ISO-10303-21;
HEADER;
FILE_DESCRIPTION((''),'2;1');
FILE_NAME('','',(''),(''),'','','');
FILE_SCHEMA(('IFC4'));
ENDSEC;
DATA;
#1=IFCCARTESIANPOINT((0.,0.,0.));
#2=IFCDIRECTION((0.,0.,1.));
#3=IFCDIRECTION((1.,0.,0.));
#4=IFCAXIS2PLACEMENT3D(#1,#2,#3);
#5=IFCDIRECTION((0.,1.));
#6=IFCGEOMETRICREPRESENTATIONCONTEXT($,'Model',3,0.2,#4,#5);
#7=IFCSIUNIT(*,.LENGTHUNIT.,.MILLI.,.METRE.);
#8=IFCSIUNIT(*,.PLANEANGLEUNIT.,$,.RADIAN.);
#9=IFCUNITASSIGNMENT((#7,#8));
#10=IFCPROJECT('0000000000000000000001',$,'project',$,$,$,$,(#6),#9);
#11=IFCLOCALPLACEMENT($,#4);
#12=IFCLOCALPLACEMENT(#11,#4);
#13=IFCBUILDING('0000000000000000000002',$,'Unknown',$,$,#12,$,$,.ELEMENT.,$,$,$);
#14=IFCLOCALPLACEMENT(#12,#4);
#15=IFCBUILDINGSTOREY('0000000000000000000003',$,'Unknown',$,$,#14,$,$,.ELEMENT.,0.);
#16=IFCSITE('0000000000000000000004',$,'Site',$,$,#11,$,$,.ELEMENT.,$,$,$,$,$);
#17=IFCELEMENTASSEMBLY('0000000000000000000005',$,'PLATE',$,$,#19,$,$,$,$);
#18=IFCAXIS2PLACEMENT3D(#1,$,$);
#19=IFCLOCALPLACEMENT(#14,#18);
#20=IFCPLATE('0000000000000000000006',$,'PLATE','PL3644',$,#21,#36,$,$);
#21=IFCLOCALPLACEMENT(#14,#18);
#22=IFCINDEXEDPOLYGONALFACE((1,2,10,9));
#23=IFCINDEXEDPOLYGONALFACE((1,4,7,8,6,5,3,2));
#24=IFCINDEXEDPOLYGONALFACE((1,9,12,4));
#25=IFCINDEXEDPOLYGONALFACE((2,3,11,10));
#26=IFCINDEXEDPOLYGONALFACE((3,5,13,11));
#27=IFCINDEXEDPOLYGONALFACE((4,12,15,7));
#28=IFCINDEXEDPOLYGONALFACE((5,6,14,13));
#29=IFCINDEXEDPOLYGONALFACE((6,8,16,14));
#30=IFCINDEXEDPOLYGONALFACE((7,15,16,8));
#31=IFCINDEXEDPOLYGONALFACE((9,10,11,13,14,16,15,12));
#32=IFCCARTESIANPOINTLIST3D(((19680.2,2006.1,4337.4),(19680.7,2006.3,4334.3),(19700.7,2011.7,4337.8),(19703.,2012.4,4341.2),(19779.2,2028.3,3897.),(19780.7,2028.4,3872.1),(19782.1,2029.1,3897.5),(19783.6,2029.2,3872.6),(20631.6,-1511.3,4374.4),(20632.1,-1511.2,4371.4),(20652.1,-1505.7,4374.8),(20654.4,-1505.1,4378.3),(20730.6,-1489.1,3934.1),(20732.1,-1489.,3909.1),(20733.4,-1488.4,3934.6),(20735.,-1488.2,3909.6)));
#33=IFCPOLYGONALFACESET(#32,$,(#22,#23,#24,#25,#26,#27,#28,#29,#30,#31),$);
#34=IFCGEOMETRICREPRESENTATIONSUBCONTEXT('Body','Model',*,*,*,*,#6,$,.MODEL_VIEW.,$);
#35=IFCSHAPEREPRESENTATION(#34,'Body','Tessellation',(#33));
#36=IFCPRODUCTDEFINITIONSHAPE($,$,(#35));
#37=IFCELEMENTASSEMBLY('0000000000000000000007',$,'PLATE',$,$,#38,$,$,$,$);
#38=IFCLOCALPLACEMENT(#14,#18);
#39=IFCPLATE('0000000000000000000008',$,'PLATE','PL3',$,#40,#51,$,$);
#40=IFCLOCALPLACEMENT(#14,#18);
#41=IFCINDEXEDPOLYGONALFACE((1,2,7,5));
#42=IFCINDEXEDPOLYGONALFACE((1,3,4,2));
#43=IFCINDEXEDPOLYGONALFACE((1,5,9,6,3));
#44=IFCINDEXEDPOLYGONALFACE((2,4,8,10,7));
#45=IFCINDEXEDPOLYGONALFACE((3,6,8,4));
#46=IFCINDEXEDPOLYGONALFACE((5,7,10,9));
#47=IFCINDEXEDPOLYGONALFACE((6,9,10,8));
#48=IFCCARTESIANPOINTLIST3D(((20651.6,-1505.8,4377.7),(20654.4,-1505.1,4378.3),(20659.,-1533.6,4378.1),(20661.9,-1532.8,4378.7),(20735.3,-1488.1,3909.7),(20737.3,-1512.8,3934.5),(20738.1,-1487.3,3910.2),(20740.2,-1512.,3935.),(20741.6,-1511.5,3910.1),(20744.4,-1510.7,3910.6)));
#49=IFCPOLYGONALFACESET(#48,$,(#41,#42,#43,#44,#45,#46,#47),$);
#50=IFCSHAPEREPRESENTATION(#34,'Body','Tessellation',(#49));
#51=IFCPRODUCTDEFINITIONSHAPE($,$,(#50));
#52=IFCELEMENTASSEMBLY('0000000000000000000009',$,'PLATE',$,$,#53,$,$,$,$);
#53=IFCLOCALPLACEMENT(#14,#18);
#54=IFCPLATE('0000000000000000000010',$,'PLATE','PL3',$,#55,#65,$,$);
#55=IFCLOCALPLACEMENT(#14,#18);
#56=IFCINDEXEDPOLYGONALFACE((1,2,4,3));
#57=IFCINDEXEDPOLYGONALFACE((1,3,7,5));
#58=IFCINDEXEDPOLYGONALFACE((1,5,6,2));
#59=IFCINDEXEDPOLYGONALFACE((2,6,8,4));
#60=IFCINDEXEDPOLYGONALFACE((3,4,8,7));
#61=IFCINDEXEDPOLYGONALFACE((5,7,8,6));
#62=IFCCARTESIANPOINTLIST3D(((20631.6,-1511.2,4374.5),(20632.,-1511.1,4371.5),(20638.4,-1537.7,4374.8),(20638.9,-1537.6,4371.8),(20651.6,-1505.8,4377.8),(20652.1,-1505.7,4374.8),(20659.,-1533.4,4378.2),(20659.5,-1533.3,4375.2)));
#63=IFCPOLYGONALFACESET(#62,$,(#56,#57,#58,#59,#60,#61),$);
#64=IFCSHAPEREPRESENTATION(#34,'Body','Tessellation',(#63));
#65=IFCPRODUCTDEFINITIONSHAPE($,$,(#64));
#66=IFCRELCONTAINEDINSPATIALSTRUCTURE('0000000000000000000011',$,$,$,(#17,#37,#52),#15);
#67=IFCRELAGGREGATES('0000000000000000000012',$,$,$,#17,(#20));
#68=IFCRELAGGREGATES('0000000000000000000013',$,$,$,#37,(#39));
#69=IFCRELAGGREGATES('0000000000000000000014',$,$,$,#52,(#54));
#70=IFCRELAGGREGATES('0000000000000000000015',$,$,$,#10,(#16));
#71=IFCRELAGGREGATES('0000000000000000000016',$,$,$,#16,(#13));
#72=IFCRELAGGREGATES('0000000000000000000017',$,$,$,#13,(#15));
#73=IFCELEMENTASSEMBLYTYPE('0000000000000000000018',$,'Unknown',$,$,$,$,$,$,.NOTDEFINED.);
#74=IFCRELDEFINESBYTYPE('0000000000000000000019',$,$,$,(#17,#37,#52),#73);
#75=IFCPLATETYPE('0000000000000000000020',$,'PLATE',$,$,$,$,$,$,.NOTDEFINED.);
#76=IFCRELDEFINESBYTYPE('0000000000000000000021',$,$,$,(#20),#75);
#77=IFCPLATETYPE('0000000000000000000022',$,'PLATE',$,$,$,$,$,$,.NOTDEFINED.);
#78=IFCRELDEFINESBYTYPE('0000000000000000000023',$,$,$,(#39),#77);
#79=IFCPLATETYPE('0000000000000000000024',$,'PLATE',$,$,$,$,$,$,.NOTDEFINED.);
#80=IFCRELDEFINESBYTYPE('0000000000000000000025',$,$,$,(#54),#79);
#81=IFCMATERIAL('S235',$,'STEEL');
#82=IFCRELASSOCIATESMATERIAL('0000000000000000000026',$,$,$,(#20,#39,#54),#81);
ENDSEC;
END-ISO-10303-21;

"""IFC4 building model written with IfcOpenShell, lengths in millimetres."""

from ifc_helpers import new_model, si_unit, direction, frame, origin_with_axes, place, context, subcontext, project, spatial, line, indexed_curve, outline, extrude, material, material_profile, profile_set, profile_usage, type_object, element, aggregate, save


model = new_model("IFC4")

# Units and contexts
model_context = context("Model", 3, precision=0.2, world=origin_with_axes(), true_north=direction((0.0, 1.0)))
body_context = subcontext(model_context, "Body", "Model", "MODEL_VIEW")
ifc_project = project(units=[si_unit("LENGTHUNIT", "METRE", prefix="MILLI"), si_unit("PLANEANGLEUNIT", "RADIAN")], contexts=[model_context])

# Site, building, storey
site_placement = place(None, origin_with_axes())
site = spatial("IfcSite", under=ifc_project, at=site_placement, Name="Site", CompositionType="ELEMENT")
building_placement = place(site_placement, origin_with_axes())
building = spatial("IfcBuilding", under=site, at=building_placement, Name="Unknown", CompositionType="ELEMENT")
storey_placement = place(building_placement, origin_with_axes())
storey = spatial("IfcBuildingStorey", under=building, at=storey_placement, Name="Unknown", CompositionType="ELEMENT", Elevation=0.0)

# Shared definitions
element_assembly_type = type_object("IfcElementAssemblyType", Name="Unknown", PredefinedType="NOTDEFINED")

# Shared definitions
ifc_material_1 = material(Name="S235", Category="STEEL")

# Element assemblies, plates
assembly_1_placement = place(storey_placement, frame((20155.9, 247.4, 4355.9), z_axis=(-0.261079, 0.965264, -0.010168), x_axis=(0.952375, 0.259284, 0.160478)))
assembly_1 = element("IfcElementAssembly", 1, at=assembly_1_placement, inside=storey, type_object=element_assembly_type, Name="PLATE")
ifc_material_profile_1 = material_profile(ifc_material_1, outline(indexed_curve([(0.0, 0.0), (24.0, 0.0), (32.4, 450.9), (29.8, 475.8), (26.9, 475.8), (29.4, 450.9), (21.0, 3.0), (0.0, 3.1)], segments=[line(1, 2, 3, 4, 5, 6, 7, 8, 1)])), Name="PL3644")
ifc_profile_set_1 = profile_set([ifc_material_profile_1])
ifc_profile_usage_1 = profile_usage(ifc_profile_set_1, cardinal=5)
plate_type_1 = type_object("IfcPlateType", Name="PLATE", PredefinedType="NOTDEFINED")
plate_1_placement = place(assembly_1_placement, origin_with_axes())
plate_1 = element("IfcPlate", 2, at=plate_1_placement, type_object=plate_type_1, material=ifc_profile_usage_1, Name="PLATE", Description="PL3644", context=body_context, shape_type="SolidModel", body=[
    extrude(outline(indexed_curve([(0.0, 0.0), (24.0, 0.0), (32.4, 450.9), (29.8, 475.8), (26.9, 475.8), (29.4, 450.9), (21.0, 3.0), (0.0, 3.1)], segments=[line(1, 2, 3, 4, 5, 6, 7, 8, 1)])), frame((0.0, 0.0, 1822.0), z_axis=(0.0, 0.0, 1.0), x_axis=(1.0, 0.0, 0.0)), (0.0, 0.0, -1.0), 3644.0),
])
aggregate(assembly_1, [plate_1])
assembly_2_placement = place(storey_placement, frame((20653.0, -1505.4, 4378.0), z_axis=(0.94912, 0.258677, 0.179601), x_axis=(0.26051, -0.965374, 0.013724)))
assembly_2 = element("IfcElementAssembly", 3, at=assembly_2_placement, inside=storey, type_object=element_assembly_type, Name="PLATE")
ifc_material_profile_2 = material_profile(ifc_material_1, outline(indexed_curve([(0.0, 0.0), (28.7, 0.0), (23.0, 450.9), (22.5, 475.7), (-1.7, 475.8)], segments=[line(1, 2, 3, 4, 5, 1)])), Name="PL3")
ifc_profile_set_2 = profile_set([ifc_material_profile_2])
ifc_profile_usage_2 = profile_usage(ifc_profile_set_2, cardinal=5)
plate_type_2 = type_object("IfcPlateType", Name="PLATE", PredefinedType="NOTDEFINED")
plate_2_placement = place(assembly_2_placement, origin_with_axes())
plate_2 = element("IfcPlate", 4, at=plate_2_placement, type_object=plate_type_2, material=ifc_profile_usage_2, Name="PLATE", Description="PL3", context=body_context, shape_type="SolidModel", body=[
    extrude(outline(indexed_curve([(0.0, 0.0), (28.7, 0.0), (23.0, 450.9), (22.5, 475.7), (-1.7, 475.8)], segments=[line(1, 2, 3, 4, 5, 1)])), frame((0.0, 0.0, 1.5), z_axis=(0.0, 0.0, 1.0), x_axis=(1.0, 0.0, 0.0)), (0.0, 0.0, -1.0), 3.0),
])
aggregate(assembly_2, [plate_2])
assembly_3_placement = place(storey_placement, frame((20638.6, -1537.6, 4373.3), z_axis=(-0.15599, -0.028213, 0.987356), x_axis=(0.966796, 0.200481, 0.158471)))
assembly_3 = element("IfcElementAssembly", 5, at=assembly_3_placement, inside=storey, type_object=element_assembly_type, Name="PLATE")
ifc_material_profile_3 = material_profile(ifc_material_1, outline(indexed_curve([(0.0, 0.0), (21.3, 0.0), (19.6, 28.6), (-1.3, 27.3)], segments=[line(1, 2, 3, 4, 1)])), Name="PL3")
ifc_profile_set_3 = profile_set([ifc_material_profile_3])
ifc_profile_usage_3 = profile_usage(ifc_profile_set_3, cardinal=5)
plate_type_3 = type_object("IfcPlateType", Name="PLATE", PredefinedType="NOTDEFINED")
plate_3_placement = place(assembly_3_placement, origin_with_axes())
plate_3 = element("IfcPlate", 6, at=plate_3_placement, type_object=plate_type_3, material=ifc_profile_usage_3, Name="PLATE", Description="PL3", context=body_context, shape_type="SolidModel", body=[
    extrude(outline(indexed_curve([(0.0, 0.0), (21.3, 0.0), (19.6, 28.6), (-1.3, 27.3)], segments=[line(1, 2, 3, 4, 1)])), frame((0.0, 0.0, 1.5), z_axis=(0.0, 0.0, 1.0), x_axis=(1.0, 0.0, 0.0)), (0.0, 0.0, -1.0), 3.0),
])
aggregate(assembly_3, [plate_3])

save(model, "model.ifc")
